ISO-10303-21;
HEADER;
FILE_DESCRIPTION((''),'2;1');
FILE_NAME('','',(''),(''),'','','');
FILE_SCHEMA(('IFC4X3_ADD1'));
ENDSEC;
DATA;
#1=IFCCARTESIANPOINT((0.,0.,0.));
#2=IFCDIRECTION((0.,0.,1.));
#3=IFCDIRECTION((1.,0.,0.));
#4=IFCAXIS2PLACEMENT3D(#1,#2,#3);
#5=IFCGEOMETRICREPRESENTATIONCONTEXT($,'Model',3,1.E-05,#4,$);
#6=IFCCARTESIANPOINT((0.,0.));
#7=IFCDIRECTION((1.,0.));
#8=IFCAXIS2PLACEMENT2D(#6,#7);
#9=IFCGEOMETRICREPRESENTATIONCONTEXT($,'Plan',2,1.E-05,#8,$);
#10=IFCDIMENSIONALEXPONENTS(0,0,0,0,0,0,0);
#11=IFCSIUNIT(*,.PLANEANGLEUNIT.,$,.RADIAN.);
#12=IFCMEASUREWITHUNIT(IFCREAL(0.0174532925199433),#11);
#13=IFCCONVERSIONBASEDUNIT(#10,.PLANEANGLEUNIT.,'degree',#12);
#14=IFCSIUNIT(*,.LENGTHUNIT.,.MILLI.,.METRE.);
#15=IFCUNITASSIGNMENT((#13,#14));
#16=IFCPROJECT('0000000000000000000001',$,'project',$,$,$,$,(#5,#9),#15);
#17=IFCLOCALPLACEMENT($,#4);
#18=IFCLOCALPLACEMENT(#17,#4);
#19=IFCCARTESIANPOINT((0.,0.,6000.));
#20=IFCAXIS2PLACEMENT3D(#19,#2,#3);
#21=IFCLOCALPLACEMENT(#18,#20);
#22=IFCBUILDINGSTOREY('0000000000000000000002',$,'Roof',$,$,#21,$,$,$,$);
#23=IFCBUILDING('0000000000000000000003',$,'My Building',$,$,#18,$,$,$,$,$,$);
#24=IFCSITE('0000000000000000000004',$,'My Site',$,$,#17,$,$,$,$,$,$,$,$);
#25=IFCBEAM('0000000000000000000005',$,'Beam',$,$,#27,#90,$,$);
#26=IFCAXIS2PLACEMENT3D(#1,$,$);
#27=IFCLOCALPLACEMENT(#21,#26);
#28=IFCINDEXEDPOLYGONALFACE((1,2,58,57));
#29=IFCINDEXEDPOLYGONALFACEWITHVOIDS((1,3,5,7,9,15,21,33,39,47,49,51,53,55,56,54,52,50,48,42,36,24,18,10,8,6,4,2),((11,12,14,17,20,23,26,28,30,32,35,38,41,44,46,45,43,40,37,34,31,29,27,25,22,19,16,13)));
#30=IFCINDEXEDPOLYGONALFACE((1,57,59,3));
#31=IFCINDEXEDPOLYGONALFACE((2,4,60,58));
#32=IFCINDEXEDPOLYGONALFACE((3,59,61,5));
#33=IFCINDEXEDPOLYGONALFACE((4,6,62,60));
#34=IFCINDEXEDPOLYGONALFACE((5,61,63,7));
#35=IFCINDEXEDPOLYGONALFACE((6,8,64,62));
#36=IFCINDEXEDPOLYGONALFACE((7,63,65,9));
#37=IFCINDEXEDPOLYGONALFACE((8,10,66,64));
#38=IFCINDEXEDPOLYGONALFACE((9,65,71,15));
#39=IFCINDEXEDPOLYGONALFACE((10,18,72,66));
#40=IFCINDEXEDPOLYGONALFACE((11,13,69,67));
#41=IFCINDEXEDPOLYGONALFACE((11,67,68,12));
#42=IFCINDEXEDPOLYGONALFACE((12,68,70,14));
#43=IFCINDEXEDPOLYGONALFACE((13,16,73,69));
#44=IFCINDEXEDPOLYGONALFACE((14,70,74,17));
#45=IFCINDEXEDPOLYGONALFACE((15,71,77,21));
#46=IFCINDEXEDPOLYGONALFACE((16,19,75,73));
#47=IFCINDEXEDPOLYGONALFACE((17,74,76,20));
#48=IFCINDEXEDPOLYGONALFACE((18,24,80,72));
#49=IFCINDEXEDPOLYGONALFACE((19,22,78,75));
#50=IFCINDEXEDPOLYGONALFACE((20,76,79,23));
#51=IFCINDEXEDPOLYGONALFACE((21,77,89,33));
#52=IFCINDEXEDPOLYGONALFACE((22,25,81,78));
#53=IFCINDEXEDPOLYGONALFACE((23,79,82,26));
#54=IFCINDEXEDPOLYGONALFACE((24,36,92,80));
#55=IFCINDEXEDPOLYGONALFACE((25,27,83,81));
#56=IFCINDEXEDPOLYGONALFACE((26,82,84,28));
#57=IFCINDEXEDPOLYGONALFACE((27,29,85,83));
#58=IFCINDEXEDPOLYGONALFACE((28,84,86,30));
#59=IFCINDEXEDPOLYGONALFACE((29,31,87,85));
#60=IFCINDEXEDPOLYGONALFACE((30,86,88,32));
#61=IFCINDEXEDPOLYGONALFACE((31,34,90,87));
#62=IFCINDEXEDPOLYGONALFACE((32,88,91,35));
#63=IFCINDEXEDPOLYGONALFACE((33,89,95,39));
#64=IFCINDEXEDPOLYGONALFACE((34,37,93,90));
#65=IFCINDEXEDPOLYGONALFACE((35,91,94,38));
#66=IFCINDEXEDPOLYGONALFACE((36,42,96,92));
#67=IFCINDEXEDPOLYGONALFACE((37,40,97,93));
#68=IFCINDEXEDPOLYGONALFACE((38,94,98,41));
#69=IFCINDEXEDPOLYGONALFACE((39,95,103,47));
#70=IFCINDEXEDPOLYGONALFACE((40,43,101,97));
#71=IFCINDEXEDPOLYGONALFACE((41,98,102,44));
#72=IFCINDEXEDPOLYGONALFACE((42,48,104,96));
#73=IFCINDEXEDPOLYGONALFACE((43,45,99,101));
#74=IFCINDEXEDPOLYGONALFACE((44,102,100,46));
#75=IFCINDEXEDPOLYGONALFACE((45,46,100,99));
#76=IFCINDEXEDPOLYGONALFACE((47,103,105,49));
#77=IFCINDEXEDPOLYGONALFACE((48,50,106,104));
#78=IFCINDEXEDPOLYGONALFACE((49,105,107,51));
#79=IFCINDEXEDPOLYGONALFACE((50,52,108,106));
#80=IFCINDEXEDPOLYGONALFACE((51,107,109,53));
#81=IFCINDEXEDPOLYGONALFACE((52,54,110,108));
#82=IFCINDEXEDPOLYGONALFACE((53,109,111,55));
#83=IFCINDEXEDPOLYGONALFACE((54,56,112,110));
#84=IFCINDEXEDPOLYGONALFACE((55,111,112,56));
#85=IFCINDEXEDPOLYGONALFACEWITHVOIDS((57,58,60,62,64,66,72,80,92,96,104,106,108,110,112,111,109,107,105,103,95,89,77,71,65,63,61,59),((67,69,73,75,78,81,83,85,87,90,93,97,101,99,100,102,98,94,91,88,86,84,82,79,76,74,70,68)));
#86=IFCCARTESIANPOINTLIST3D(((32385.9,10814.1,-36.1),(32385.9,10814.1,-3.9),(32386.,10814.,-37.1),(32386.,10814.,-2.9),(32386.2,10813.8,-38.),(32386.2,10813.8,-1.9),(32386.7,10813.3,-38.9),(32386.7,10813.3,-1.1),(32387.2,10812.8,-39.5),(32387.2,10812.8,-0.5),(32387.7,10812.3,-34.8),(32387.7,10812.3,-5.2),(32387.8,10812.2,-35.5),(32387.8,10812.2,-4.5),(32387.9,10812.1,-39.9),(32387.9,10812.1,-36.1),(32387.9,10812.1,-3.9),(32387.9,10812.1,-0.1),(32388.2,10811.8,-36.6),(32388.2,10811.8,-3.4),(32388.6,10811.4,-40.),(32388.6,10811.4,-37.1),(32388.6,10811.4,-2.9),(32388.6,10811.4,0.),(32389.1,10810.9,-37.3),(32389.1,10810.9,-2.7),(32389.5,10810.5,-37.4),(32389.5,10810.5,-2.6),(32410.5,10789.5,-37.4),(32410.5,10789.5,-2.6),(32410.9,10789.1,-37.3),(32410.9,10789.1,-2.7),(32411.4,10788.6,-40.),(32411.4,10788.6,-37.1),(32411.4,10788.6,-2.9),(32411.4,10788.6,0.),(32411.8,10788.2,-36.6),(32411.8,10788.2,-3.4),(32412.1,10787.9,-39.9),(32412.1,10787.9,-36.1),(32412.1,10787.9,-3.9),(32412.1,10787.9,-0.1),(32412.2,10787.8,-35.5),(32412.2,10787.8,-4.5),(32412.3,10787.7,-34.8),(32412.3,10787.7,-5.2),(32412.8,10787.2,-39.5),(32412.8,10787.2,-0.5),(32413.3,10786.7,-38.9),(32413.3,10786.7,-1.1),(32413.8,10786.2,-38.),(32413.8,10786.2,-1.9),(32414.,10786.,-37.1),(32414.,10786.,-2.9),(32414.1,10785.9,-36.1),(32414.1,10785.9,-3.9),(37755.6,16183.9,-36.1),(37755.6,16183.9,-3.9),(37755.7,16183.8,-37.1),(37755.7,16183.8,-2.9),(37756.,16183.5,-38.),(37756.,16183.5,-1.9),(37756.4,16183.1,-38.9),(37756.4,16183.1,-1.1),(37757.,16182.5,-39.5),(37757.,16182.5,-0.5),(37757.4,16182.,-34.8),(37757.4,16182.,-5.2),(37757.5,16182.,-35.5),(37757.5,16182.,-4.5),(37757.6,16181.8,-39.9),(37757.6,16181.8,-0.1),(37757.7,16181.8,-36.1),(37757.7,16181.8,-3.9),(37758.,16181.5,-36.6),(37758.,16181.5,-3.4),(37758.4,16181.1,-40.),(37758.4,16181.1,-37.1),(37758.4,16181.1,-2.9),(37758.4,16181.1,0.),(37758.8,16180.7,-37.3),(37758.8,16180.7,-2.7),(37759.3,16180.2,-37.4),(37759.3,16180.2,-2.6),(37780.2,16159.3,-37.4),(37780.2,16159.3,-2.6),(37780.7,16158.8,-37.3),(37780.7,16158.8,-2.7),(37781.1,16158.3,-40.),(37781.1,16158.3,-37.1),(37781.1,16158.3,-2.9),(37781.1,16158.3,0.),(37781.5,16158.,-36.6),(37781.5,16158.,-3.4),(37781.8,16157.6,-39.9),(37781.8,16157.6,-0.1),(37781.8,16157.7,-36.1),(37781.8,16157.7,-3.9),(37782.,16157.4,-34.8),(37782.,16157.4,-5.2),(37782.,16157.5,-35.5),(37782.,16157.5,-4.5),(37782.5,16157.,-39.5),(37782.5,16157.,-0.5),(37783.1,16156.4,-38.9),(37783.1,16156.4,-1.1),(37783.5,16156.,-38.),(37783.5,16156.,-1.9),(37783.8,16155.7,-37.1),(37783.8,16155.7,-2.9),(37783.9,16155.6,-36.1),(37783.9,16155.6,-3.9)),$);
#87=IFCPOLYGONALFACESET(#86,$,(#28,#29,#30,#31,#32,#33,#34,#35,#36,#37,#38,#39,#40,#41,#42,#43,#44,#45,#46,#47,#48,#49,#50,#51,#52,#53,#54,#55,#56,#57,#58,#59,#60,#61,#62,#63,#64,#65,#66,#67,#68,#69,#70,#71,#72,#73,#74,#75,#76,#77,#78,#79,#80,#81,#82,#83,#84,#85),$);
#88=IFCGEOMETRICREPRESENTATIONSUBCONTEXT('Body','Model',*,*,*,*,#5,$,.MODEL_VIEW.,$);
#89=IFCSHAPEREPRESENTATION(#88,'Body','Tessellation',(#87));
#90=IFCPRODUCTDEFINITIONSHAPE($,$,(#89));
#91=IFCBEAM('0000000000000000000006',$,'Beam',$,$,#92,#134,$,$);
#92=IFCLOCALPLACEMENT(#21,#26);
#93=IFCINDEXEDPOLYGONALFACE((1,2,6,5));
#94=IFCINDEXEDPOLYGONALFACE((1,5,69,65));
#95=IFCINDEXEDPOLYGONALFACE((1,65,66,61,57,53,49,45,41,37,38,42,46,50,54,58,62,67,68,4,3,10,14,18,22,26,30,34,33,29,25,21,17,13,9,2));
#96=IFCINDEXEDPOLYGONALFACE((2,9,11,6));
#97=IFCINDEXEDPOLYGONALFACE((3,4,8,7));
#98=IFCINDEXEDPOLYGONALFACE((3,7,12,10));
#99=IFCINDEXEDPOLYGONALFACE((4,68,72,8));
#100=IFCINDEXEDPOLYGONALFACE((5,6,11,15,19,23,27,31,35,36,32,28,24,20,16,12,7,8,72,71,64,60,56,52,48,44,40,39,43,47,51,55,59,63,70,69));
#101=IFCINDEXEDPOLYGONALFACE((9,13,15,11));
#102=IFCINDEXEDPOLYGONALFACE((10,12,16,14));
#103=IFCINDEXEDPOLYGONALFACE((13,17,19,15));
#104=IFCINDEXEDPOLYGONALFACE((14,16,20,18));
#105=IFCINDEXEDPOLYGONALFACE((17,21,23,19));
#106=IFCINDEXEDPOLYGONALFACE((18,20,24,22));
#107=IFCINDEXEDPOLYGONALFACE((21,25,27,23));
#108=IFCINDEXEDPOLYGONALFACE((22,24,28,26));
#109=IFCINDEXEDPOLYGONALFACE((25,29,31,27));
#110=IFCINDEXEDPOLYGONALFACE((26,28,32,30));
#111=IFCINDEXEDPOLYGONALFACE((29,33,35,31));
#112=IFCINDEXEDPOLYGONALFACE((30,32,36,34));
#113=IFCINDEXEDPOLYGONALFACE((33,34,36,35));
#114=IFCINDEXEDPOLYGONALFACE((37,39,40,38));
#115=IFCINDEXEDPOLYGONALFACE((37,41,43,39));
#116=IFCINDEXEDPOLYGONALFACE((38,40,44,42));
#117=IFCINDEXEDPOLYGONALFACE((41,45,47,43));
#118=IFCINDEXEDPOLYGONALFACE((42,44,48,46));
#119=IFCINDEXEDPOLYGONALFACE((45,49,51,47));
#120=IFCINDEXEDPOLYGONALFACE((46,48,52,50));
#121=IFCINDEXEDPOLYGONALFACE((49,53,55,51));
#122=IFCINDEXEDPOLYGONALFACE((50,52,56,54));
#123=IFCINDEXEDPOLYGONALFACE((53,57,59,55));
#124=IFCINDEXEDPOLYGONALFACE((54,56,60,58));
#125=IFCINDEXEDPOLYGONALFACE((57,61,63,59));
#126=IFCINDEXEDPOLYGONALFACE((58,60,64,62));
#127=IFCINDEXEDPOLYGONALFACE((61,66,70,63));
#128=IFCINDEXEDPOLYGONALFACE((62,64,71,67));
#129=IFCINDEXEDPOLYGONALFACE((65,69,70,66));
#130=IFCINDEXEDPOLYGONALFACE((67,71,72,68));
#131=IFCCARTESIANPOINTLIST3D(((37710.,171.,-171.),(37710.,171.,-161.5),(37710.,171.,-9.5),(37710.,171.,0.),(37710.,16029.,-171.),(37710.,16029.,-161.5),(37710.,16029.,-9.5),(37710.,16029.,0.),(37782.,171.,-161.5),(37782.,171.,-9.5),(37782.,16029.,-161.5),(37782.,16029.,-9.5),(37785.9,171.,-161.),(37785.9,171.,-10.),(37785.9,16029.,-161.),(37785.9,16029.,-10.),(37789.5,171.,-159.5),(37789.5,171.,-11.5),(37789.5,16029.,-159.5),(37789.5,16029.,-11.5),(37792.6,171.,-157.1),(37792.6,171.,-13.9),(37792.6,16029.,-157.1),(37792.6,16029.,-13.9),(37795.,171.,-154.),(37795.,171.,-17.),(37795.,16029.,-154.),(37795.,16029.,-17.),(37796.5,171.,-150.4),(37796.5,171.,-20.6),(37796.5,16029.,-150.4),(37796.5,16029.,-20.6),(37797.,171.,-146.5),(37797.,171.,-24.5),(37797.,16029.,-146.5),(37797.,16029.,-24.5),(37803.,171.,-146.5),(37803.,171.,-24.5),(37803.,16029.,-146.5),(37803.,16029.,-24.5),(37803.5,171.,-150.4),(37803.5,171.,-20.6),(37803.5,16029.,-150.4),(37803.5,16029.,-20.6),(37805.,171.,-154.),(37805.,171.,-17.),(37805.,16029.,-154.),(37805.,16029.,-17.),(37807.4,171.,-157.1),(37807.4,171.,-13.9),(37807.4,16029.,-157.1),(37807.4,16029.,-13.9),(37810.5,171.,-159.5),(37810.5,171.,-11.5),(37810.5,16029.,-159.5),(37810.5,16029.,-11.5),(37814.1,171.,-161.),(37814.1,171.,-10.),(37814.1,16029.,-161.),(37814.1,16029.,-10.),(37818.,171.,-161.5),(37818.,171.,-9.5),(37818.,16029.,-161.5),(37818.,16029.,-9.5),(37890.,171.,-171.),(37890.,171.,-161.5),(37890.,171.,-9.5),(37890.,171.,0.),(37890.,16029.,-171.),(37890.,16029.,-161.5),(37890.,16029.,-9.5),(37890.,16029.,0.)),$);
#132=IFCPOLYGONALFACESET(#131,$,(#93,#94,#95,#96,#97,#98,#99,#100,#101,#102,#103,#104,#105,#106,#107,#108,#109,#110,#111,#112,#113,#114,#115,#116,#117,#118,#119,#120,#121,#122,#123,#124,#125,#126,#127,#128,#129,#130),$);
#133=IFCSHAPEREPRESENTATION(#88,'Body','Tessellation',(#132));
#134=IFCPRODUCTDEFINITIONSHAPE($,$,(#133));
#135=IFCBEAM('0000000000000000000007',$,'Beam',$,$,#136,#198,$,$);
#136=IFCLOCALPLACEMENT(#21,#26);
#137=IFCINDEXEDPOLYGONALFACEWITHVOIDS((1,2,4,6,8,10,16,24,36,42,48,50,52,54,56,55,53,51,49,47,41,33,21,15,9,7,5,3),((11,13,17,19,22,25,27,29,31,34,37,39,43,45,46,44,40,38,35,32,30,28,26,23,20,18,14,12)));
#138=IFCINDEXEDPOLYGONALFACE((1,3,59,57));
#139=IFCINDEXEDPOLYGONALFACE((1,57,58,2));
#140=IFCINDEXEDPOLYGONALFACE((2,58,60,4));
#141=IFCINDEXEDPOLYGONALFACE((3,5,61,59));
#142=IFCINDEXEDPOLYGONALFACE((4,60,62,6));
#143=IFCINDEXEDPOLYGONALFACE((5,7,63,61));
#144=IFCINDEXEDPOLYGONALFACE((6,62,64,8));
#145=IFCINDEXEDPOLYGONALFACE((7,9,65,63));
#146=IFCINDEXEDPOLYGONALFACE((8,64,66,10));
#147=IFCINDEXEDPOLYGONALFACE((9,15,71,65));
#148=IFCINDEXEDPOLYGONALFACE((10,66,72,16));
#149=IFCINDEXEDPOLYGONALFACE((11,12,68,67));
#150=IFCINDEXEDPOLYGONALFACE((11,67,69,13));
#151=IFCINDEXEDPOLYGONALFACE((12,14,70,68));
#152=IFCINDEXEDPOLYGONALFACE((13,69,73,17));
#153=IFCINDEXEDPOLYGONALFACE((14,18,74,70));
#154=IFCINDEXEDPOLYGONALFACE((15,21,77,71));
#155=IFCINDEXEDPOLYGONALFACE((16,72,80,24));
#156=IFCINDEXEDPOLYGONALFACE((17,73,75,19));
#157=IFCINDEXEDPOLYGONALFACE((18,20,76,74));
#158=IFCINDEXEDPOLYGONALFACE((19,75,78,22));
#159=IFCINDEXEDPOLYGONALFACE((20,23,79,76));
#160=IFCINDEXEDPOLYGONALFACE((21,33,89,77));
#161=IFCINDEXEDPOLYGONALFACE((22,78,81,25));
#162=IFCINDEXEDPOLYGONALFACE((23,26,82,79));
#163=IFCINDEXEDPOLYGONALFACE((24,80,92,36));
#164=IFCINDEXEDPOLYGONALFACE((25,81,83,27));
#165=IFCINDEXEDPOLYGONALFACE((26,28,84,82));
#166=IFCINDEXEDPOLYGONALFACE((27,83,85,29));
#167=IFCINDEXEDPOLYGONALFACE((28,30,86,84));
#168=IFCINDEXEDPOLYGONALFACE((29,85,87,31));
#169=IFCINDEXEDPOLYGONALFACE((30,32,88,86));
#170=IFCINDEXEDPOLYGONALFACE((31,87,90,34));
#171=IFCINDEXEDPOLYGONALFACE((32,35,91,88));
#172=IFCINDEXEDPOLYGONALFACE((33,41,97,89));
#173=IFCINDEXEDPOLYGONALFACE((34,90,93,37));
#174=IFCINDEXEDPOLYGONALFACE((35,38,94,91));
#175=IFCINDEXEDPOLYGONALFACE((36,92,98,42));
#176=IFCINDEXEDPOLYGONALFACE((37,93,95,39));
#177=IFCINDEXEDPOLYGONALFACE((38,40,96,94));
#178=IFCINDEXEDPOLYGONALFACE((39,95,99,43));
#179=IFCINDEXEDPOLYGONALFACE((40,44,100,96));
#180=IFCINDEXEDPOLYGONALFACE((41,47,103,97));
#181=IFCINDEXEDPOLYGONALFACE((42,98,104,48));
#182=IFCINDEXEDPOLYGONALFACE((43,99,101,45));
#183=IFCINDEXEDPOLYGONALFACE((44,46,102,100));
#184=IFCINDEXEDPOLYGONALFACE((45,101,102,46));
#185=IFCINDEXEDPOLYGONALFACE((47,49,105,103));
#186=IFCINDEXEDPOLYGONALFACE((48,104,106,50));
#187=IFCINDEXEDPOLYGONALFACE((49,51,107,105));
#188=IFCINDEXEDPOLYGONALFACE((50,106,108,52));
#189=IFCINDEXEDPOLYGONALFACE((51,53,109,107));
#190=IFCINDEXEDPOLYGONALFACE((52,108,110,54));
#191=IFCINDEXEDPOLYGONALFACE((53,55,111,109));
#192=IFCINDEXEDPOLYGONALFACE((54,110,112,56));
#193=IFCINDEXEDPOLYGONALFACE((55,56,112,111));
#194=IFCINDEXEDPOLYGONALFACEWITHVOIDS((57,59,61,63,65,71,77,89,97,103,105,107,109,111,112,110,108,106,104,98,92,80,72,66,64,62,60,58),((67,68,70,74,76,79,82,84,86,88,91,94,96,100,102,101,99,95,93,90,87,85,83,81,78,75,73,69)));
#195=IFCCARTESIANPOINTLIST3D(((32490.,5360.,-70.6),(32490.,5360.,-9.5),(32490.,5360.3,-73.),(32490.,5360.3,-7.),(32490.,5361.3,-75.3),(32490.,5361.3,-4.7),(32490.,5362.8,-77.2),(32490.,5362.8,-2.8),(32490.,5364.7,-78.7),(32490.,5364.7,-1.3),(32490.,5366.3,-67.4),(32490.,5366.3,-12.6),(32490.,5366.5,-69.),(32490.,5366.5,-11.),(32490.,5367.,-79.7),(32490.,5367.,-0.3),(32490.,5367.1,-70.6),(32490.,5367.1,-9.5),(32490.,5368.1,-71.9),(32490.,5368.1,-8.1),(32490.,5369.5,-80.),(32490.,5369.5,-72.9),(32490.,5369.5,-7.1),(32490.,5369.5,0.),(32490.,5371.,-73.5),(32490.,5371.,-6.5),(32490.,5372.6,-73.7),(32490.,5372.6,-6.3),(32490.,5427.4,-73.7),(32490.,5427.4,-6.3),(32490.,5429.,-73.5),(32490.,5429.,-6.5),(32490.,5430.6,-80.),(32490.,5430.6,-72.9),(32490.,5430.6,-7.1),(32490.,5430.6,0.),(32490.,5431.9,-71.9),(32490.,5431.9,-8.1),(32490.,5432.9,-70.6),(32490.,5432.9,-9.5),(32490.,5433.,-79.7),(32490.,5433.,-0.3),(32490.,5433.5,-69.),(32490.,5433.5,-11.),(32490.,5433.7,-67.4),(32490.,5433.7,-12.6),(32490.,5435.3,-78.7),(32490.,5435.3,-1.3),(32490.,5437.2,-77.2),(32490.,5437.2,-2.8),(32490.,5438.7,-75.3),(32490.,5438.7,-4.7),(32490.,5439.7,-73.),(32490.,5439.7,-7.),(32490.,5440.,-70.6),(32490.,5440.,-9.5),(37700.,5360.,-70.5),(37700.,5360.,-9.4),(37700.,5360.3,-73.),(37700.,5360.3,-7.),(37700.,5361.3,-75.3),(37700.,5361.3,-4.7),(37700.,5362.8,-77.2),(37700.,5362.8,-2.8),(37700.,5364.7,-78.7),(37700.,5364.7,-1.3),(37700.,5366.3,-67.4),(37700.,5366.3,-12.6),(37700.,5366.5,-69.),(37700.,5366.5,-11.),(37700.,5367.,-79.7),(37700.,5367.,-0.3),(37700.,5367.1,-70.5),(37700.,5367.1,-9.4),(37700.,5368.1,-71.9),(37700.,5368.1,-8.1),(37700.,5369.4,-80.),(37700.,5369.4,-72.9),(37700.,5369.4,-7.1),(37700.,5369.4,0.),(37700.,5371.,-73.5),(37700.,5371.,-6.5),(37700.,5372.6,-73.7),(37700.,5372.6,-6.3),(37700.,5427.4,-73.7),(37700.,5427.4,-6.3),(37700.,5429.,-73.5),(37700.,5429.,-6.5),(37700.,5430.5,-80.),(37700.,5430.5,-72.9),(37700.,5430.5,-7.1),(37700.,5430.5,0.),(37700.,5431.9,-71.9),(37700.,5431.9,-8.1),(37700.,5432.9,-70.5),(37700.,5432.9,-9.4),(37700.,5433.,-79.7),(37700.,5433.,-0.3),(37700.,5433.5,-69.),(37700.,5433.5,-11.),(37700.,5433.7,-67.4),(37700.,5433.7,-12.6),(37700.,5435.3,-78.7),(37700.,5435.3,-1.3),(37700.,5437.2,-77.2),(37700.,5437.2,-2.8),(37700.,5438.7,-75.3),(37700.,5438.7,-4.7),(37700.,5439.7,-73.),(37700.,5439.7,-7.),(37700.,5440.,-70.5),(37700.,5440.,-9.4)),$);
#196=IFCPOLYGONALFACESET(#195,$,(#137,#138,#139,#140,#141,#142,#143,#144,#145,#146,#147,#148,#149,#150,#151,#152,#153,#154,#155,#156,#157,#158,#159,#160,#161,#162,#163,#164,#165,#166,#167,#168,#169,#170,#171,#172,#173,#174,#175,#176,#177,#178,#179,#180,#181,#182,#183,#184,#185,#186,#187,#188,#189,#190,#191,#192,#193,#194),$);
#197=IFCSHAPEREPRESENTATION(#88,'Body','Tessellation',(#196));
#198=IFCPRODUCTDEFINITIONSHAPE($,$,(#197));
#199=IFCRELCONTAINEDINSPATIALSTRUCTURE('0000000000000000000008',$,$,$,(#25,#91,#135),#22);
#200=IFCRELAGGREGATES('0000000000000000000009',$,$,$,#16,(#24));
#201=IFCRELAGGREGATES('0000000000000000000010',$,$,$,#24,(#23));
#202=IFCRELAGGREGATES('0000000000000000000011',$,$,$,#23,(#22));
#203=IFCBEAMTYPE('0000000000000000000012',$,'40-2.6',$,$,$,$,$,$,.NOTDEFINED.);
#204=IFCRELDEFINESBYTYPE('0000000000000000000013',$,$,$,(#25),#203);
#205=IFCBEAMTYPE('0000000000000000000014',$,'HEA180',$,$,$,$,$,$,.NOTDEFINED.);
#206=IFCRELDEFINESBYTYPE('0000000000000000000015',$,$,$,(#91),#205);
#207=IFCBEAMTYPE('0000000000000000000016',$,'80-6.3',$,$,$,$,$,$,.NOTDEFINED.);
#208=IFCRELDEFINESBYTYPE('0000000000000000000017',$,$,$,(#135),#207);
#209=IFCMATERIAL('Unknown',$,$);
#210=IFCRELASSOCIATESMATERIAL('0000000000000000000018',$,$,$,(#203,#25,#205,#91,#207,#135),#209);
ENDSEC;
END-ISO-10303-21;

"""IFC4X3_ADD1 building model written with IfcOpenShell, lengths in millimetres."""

from ifc_helpers import new_model, entity, si_unit, converted_unit, frame, origin_with_axes, origin_2d_with_axis, place, context, subcontext, project, spatial, hollow_rectangle, i_section, extrude, material, material_profile, profile_set, profile_usage, type_object, element, save


model = new_model("IFC4X3_ADD1")

# Units and contexts
model_context = context("Model", 3, precision=1e-05, world=origin_with_axes())
plan_context = context("Plan", 2, precision=1e-05, world=origin_2d_with_axis())
body_context = subcontext(model_context, "Body", "Model", "MODEL_VIEW")
ifc_project = project(units=[converted_unit("PLANEANGLEUNIT", "degree", entity("IfcReal", 0.0174532925199433), si_unit("PLANEANGLEUNIT", "RADIAN"), dimensions=[0, 0, 0, 0, 0, 0, 0]), si_unit("LENGTHUNIT", "METRE", prefix="MILLI")], contexts=[model_context, plan_context])

# Site, building, storey
site_placement = place(None, origin_with_axes())
site = spatial("IfcSite", under=ifc_project, at=site_placement, Name="My Site")
building_placement = place(site_placement, origin_with_axes())
building = spatial("IfcBuilding", under=site, at=building_placement, Name="My Building")
storey_placement = place(building_placement, frame((0.0, 0.0, 6000.0), z_axis=(0.0, 0.0, 1.0), x_axis=(1.0, 0.0, 0.0)))
storey = spatial("IfcBuildingStorey", under=building, at=storey_placement, Name="Roof")

# Beams
ifc_material = material(Name="Unknown")
ifc_material_profile_1 = material_profile(ifc_material, hollow_rectangle(XDim=40.0, YDim=40.0, WallThickness=2.6, InnerFilletRadius=2.6, OuterFilletRadius=3.9))
ifc_profile_set_1 = profile_set([ifc_material_profile_1])
beam_type_1 = type_object("IfcBeamType", Name="40-2.6", PredefinedType="NOTDEFINED", material=ifc_profile_set_1)
ifc_profile_usage_1 = profile_usage(ifc_profile_set_1, cardinal=8)
beam_1_placement = place(storey_placement, frame((32400.0, 10800.0, 0.0), z_axis=(0.707107, 0.707107, 0.0), x_axis=(-0.707107, 0.707107, 0.0)))
element("IfcBeam", 1, at=beam_1_placement, inside=storey, type_object=beam_type_1, material=ifc_profile_usage_1, Name="Beam", context=body_context, shape_type="SweptSolid", body=[
    extrude(hollow_rectangle(XDim=40.0, YDim=40.0, WallThickness=2.6, InnerFilletRadius=2.6, OuterFilletRadius=3.9), frame((0.0, -20.0, 0.0), z_axis=(0.0, 0.0, 1.0), x_axis=(1.0, 0.0, 0.0)), (0.0, 0.0, 1.0), 7594.0),
])
ifc_material_profile_2 = material_profile(ifc_material, i_section(OverallWidth=180.0, OverallDepth=171.0, WebThickness=6.0, FlangeThickness=9.5, FilletRadius=15.0))
ifc_profile_set_2 = profile_set([ifc_material_profile_2])
ifc_profile_usage_2 = profile_usage(ifc_profile_set_2, cardinal=8)
beam_type_2 = type_object("IfcBeamType", Name="HEA180", PredefinedType="NOTDEFINED", material=ifc_profile_set_2)
beam_2_placement = place(storey_placement, frame((37800.0, 171.0, 0.0), z_axis=(0.000001, 1.0, 0.0), x_axis=(-1.0, 0.000001, 0.0)))
element("IfcBeam", 2, at=beam_2_placement, inside=storey, type_object=beam_type_2, material=ifc_profile_usage_2, Name="Beam", context=body_context, shape_type="SweptSolid", body=[
    extrude(i_section(OverallWidth=180.0, OverallDepth=171.0, WebThickness=6.0, FlangeThickness=9.5, FilletRadius=15.0), frame((0.0, -85.5, 0.0), z_axis=(0.0, 0.0, 1.0), x_axis=(1.0, 0.0, 0.0)), (0.0, 0.0, 1.0), 15858.0),
])
ifc_material_profile_3 = material_profile(ifc_material, hollow_rectangle(XDim=80.0, YDim=80.0, WallThickness=6.3, InnerFilletRadius=6.3, OuterFilletRadius=9.4))
ifc_profile_set_3 = profile_set([ifc_material_profile_3])
ifc_profile_usage_3 = profile_usage(ifc_profile_set_3, cardinal=8)
beam_type_3 = type_object("IfcBeamType", Name="80-6.3", PredefinedType="NOTDEFINED", material=ifc_profile_set_3)
beam_3_placement = place(storey_placement, frame((32490.0, 5400.0, 0.0), z_axis=(1.0, 0.0, 0.0), x_axis=(0.0, 1.0, 0.0)))
element("IfcBeam", 3, at=beam_3_placement, inside=storey, type_object=beam_type_3, material=ifc_profile_usage_3, Name="Beam", context=body_context, shape_type="SweptSolid", body=[
    extrude(hollow_rectangle(XDim=80.0, YDim=80.0, WallThickness=6.3, InnerFilletRadius=6.3, OuterFilletRadius=9.4), frame((0.0, -40.0, 0.0), z_axis=(0.0, 0.0, 1.0), x_axis=(1.0, 0.0, 0.0)), (0.0, 0.0, 1.0), 5210.0),
])

save(model, "model.ifc")
